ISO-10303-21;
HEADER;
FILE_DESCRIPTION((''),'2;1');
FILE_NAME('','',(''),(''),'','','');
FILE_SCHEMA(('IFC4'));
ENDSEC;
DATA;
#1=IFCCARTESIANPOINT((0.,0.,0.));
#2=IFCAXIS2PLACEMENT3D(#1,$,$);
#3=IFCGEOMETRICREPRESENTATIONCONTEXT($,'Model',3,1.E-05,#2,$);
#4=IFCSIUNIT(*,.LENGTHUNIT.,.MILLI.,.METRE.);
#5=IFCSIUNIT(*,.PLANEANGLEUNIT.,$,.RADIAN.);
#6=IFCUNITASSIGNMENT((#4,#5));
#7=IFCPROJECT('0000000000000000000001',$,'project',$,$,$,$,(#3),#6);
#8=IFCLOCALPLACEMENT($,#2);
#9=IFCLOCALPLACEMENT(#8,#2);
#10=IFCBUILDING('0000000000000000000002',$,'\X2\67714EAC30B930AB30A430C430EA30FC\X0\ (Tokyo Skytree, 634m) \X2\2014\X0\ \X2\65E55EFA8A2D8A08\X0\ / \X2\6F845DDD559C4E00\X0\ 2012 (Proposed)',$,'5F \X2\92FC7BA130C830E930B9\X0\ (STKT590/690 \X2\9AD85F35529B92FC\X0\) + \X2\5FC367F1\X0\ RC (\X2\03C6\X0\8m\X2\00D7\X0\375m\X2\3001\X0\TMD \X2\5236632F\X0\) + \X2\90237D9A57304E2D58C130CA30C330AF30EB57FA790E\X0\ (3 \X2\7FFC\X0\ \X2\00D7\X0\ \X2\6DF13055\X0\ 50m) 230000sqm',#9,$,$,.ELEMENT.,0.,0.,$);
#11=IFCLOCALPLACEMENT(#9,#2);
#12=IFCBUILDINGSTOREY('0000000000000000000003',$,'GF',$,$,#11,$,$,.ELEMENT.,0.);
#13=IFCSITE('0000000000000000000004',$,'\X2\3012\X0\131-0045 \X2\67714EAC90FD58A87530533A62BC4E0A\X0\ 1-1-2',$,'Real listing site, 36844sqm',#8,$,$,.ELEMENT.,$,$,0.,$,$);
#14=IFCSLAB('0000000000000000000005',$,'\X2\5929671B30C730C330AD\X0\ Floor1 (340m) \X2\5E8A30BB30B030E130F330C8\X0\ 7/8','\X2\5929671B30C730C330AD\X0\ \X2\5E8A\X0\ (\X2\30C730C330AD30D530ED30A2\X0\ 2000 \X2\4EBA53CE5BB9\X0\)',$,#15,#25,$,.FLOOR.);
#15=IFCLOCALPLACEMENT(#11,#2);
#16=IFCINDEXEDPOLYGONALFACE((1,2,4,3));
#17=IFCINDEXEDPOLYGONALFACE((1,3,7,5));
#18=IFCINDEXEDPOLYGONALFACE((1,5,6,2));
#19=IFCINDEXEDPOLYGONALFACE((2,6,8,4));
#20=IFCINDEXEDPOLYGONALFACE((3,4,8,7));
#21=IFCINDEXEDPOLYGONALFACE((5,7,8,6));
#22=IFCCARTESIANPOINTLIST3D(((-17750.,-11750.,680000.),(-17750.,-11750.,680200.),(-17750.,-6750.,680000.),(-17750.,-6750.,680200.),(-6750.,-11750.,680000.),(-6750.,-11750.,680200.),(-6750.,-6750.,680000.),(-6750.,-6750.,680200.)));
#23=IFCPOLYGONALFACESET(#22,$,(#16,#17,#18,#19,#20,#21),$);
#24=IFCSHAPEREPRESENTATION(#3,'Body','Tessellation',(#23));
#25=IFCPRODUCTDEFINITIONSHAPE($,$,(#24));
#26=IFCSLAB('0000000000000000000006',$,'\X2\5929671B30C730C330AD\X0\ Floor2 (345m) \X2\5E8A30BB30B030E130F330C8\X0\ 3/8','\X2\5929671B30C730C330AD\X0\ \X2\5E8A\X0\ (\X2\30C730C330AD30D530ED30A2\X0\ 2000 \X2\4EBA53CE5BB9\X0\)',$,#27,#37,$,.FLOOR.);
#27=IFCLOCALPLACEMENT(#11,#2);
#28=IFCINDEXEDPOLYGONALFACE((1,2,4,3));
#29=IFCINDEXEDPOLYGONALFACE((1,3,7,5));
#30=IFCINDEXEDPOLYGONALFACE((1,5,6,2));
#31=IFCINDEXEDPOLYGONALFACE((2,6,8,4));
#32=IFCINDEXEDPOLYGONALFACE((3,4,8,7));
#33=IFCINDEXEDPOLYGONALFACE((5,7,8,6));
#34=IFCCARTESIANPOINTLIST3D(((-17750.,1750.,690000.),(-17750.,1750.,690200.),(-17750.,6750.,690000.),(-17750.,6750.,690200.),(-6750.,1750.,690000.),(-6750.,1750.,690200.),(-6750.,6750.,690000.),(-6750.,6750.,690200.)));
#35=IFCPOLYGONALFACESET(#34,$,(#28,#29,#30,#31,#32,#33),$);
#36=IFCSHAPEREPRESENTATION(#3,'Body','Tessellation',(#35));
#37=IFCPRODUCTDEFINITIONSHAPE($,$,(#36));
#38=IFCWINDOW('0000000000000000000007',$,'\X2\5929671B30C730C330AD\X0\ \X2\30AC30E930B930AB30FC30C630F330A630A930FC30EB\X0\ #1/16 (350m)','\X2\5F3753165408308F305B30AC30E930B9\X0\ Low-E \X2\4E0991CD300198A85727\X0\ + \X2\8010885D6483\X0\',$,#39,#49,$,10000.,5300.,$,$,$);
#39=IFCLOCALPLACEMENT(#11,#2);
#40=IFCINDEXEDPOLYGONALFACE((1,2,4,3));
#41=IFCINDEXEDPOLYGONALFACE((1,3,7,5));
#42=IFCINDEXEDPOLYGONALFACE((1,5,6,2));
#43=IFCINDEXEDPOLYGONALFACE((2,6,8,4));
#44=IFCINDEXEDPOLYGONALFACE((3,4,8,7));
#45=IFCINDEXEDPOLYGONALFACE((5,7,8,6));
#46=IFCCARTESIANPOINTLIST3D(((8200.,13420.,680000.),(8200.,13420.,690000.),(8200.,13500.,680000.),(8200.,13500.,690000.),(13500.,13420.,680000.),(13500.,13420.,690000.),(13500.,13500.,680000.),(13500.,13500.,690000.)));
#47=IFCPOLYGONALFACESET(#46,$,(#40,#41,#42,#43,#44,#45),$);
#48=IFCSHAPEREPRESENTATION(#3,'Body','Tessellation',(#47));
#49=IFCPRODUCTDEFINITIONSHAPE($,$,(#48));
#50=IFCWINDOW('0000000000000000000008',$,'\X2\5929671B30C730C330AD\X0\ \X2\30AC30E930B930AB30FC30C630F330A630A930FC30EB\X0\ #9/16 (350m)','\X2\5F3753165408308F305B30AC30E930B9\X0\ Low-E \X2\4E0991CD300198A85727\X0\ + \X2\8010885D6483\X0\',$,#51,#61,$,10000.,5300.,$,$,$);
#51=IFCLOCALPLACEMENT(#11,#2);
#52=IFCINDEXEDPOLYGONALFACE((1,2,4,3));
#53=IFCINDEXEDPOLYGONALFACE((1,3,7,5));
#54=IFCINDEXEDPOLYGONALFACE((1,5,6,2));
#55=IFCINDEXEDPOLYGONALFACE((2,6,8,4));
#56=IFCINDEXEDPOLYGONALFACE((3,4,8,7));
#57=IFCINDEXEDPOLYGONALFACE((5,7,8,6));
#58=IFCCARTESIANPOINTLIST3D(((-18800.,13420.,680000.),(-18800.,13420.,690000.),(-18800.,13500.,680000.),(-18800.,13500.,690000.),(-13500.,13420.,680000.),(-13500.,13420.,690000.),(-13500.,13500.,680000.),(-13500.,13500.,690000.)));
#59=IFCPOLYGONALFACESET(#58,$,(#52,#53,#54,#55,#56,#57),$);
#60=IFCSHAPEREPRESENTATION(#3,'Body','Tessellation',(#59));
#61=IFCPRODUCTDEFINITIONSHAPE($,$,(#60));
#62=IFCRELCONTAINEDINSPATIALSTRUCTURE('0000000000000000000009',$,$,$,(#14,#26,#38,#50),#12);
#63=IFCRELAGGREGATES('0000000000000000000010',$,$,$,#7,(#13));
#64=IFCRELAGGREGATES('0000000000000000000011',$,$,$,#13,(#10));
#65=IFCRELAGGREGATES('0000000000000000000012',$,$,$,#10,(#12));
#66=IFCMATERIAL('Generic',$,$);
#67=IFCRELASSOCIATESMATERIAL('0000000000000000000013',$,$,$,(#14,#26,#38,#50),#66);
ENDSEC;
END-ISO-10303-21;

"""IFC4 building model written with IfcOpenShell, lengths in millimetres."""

from ifc_helpers import new_model, si_unit, frame, frame_2d, origin, place, context, project, spatial, rectangle, extrude, material, element, save


model = new_model("IFC4")

# Units and contexts
model_context = context("Model", 3, precision=1e-05, world=origin())
ifc_project = project(units=[si_unit("LENGTHUNIT", "METRE", prefix="MILLI"), si_unit("PLANEANGLEUNIT", "RADIAN")], contexts=[model_context])

# Site, building, storey
site_placement = place(None, origin())
site = spatial("IfcSite", under=ifc_project, at=site_placement, Name="〒131-0045 東京都墨田区押上 1-1-2", ObjectType="Real listing site, 36844sqm", CompositionType="ELEMENT", RefElevation=0.0)
building_placement = place(site_placement, origin())
building = spatial("IfcBuilding", under=site, at=building_placement, Name="東京スカイツリー (Tokyo Skytree, 634m) — 日建設計 / 澄川喜一 2012 (Proposed)", ObjectType="5F 鋼管トラス (STKT590/690 高張力鋼) + 心柱 RC (φ8m×375m、TMD 制振) + 連続地中壁ナックル基礎 (3 翼 × 深さ 50m) 230000sqm", CompositionType="ELEMENT", ElevationOfRefHeight=0.0, ElevationOfTerrain=0.0)
storey_placement = place(building_placement, origin())
storey = spatial("IfcBuildingStorey", under=building, at=storey_placement, Name="GF", CompositionType="ELEMENT", Elevation=0.0)

# Slabs
ifc_material = material(Name="Generic")
slab_1_placement = place(storey_placement, frame((0.0, -6750.0, 340000.0), x_axis=(0.0, -1.0, 0.0)))
element("IfcSlab", 1, at=slab_1_placement, inside=storey, material=ifc_material, Name="天望デッキ Floor1 (340m) 床セグメント 7/8", Description="天望デッキ 床 (デッキフロア 2000 人収容)", PredefinedType="FLOOR", context=model_context, shape_type="SweptSolid", body=[
    extrude(rectangle(XDim=11000.0, YDim=5000.0, at=frame_2d((5500.0, 2500.0))), frame((0.0, -6750.0, 340000.0), x_axis=(0.0, -1.0, 0.0)), (0.0, 0.0, 1.0), 200.0),
])
slab_2_placement = place(storey_placement, frame((0.0, 6750.0, 345000.0), x_axis=(0.0, 1.0, 0.0)))
element("IfcSlab", 2, at=slab_2_placement, inside=storey, material=ifc_material, Name="天望デッキ Floor2 (345m) 床セグメント 3/8", Description="天望デッキ 床 (デッキフロア 2000 人収容)", PredefinedType="FLOOR", context=model_context, shape_type="SweptSolid", body=[
    extrude(rectangle(XDim=11000.0, YDim=5000.0, at=frame_2d((5500.0, 2500.0))), frame((0.0, 6750.0, 345000.0), x_axis=(0.0, 1.0, 0.0)), (0.0, 0.0, 1.0), 200.0),
])

# Windows
window_1_placement = place(storey_placement, frame((13500.0, 0.0, 340000.0), x_axis=(0.0, 1.0, 0.0)))
element("IfcWindow", 3, at=window_1_placement, inside=storey, material=ifc_material, Name="天望デッキ ガラスカーテンウォール #1/16 (350m)", Description="強化合わせガラス Low-E 三重、風圧 + 耐衝撃", OverallHeight=10000.0, OverallWidth=5300.0, context=model_context, shape_type="SweptSolid", body=[
    extrude(rectangle(XDim=5300.0, YDim=80.0, at=frame_2d((2650.0, 40.0))), frame((13500.0, 0.0, 340000.0), x_axis=(0.0, 1.0, 0.0)), (0.0, 0.0, 1.0), 10000.0),
])
window_2_placement = place(storey_placement, frame((-13500.0, 0.0, 340000.0), x_axis=(0.0, -1.0, 0.0)))
element("IfcWindow", 4, at=window_2_placement, inside=storey, material=ifc_material, Name="天望デッキ ガラスカーテンウォール #9/16 (350m)", Description="強化合わせガラス Low-E 三重、風圧 + 耐衝撃", OverallHeight=10000.0, OverallWidth=5300.0, context=model_context, shape_type="SweptSolid", body=[
    extrude(rectangle(XDim=5300.0, YDim=80.0, at=frame_2d((2650.0, 40.0))), frame((-13500.0, 0.0, 340000.0), x_axis=(0.0, -1.0, 0.0)), (0.0, 0.0, 1.0), 10000.0),
])

save(model, "model.ifc")
